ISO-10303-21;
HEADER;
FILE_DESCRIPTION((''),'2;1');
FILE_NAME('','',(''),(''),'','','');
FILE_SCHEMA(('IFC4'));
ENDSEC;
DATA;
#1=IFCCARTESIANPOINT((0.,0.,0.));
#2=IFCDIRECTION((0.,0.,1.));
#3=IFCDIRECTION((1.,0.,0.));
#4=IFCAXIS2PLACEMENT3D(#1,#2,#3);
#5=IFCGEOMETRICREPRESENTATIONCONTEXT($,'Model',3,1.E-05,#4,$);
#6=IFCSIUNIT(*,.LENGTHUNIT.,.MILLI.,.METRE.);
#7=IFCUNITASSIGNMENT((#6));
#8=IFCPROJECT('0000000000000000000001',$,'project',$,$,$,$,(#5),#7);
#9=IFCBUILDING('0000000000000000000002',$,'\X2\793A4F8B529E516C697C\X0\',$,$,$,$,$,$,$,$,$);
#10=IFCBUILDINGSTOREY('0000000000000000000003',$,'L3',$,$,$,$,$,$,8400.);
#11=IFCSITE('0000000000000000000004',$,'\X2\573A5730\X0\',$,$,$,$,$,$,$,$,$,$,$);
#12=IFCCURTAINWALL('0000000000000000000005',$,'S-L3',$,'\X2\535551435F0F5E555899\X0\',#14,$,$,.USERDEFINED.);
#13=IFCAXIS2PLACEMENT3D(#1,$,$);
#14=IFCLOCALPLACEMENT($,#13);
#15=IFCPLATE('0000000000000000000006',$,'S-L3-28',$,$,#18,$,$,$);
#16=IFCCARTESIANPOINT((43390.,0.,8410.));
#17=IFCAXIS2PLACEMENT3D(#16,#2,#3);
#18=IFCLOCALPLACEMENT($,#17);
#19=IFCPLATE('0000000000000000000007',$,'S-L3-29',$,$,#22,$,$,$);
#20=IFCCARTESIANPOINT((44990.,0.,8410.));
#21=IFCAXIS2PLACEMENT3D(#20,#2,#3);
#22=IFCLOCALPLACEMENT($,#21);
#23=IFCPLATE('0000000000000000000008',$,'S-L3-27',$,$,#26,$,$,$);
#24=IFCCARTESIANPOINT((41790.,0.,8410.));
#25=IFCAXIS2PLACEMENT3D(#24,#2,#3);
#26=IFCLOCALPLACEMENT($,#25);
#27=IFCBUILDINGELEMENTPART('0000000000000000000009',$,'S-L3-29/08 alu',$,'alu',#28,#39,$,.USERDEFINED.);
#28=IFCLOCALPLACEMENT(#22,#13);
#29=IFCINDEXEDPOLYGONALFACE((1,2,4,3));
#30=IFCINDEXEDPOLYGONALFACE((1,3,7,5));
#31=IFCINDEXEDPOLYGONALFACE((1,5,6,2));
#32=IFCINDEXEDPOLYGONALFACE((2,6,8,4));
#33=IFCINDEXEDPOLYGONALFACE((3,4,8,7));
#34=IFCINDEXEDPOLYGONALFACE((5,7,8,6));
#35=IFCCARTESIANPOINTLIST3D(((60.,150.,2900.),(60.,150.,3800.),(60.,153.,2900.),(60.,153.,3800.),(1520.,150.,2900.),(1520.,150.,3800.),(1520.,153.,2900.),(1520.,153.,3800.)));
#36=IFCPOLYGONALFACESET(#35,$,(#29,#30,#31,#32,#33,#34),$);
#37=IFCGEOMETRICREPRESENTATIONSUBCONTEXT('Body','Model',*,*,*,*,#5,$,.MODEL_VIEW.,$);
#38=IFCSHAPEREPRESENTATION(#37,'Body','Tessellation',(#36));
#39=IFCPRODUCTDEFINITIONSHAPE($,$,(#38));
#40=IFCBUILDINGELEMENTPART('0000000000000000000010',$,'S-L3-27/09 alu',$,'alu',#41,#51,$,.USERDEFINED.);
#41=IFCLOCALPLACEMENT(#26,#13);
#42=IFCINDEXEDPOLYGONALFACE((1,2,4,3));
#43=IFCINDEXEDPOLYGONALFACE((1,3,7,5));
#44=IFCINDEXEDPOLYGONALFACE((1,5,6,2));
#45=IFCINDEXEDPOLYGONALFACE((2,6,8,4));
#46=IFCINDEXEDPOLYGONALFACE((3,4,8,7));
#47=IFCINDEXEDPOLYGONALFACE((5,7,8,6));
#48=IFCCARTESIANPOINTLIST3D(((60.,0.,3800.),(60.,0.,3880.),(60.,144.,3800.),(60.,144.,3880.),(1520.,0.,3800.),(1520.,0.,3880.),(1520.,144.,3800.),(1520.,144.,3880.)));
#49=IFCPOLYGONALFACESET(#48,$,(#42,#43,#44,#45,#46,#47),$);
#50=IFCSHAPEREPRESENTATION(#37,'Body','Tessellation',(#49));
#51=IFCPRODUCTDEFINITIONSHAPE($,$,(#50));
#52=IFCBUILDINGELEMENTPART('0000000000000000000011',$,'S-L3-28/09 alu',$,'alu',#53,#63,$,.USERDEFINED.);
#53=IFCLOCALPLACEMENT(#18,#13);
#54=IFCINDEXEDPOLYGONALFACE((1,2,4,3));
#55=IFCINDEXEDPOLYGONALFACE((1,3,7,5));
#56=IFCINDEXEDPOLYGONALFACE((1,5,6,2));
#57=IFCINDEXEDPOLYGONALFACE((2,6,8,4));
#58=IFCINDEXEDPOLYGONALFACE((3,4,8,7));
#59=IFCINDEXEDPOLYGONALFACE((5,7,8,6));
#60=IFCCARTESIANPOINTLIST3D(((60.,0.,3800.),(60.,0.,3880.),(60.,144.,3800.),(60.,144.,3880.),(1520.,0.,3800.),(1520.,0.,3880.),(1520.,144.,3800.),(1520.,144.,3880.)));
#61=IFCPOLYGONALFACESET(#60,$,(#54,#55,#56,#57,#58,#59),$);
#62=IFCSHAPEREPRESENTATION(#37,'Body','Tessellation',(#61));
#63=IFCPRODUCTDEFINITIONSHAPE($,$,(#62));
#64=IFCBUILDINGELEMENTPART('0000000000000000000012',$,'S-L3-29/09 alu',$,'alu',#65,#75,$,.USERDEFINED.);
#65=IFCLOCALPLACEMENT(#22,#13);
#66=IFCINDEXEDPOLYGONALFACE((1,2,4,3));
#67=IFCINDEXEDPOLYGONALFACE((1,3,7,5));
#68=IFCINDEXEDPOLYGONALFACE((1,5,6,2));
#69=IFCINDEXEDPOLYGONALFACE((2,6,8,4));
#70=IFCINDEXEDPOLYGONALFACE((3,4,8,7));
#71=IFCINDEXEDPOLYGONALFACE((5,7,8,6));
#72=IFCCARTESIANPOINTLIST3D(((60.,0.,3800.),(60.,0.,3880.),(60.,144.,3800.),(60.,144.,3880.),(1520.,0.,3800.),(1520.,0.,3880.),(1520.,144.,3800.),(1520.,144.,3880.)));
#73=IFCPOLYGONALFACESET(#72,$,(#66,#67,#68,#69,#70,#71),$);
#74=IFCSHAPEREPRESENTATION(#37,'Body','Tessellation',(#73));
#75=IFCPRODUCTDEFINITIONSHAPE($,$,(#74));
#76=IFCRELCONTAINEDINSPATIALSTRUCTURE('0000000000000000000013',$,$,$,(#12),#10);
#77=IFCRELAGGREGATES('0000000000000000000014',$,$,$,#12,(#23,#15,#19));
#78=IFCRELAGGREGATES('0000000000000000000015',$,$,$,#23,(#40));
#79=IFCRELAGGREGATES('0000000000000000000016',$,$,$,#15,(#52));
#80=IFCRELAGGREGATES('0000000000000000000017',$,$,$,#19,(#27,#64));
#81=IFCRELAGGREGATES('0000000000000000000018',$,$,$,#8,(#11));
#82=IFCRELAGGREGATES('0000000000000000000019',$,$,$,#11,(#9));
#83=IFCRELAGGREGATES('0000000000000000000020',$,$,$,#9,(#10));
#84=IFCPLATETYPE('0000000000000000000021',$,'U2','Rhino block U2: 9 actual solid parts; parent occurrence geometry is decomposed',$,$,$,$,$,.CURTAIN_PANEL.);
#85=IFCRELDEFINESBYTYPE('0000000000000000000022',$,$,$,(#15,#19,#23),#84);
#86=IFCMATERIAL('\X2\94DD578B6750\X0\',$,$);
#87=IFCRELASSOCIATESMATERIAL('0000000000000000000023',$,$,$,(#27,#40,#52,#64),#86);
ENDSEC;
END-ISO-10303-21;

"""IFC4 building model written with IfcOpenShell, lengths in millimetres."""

from ifc_helpers import new_model, si_unit, frame, frame_2d, origin, origin_with_axes, place, context, subcontext, project, spatial, rectangle, extrude, source, transform, mapped, material, type_object, element, aggregate, save


model = new_model("IFC4")

# Units and contexts
model_context = context("Model", 3, precision=1e-05, world=origin_with_axes())
body_context = subcontext(model_context, "Body", "Model", "MODEL_VIEW")
ifc_project = project(units=[si_unit("LENGTHUNIT", "METRE", prefix="MILLI")], contexts=[model_context])

# Site, building, storey
site = spatial("IfcSite", under=ifc_project, Name="场地")
building = spatial("IfcBuilding", under=site, Name="示例办公楼")
storey = spatial("IfcBuildingStorey", under=building, Name="L3", Elevation=8400.0)

# Curtain wall, plates, building element parts
curtain_wall = element("IfcCurtainWall", 1, inside=storey, Name="S-L3", ObjectType="单元式幕墙", PredefinedType="USERDEFINED")
plate_type = type_object("IfcPlateType", Name="U2", Description="Rhino block U2: 9 actual solid parts; parent occurrence geometry is decomposed", PredefinedType="CURTAIN_PANEL")
plate_1_placement = place(None, frame((43390.0, 0.0, 8410.0), z_axis=(0.0, 0.0, 1.0), x_axis=(1.0, 0.0, 0.0)))
plate_1 = element("IfcPlate", 2, at=plate_1_placement, type_object=plate_type, Name="S-L3-28")
ifc_material_1 = material(Name="铝型材")
plate_2_placement = place(None, frame((44990.0, 0.0, 8410.0), z_axis=(0.0, 0.0, 1.0), x_axis=(1.0, 0.0, 0.0)))
plate_2 = element("IfcPlate", 3, at=plate_2_placement, type_object=plate_type, Name="S-L3-29")
plate_3_placement = place(None, frame((41790.0, 0.0, 8410.0), z_axis=(0.0, 0.0, 1.0), x_axis=(1.0, 0.0, 0.0)))
plate_3 = element("IfcPlate", 4, at=plate_3_placement, type_object=plate_type, Name="S-L3-27")
aggregate(curtain_wall, [plate_3, plate_1, plate_2])
shared_shape_1 = source(origin(), body_context, "Body", "SweptSolid", [
    extrude(rectangle(XDim=1460.0, YDim=3.0, at=frame_2d((790.0, 151.5))), frame((0.0, 0.0, 2900.0)), (0.0, 0.0, 1.0), 900.0),
])
building_element_part_1_placement = place(plate_2_placement, origin())
building_element_part_1 = element("IfcBuildingElementPart", 5, at=building_element_part_1_placement, material=ifc_material_1, Name="S-L3-29/08 alu", ObjectType="alu", PredefinedType="USERDEFINED", context=body_context, shape_type="MappedRepresentation", body=[
    mapped(shared_shape_1, transform((0.0, 0.0, 0.0))),
])
shared_shape_2 = source(origin(), body_context, "Body", "SweptSolid", [
    extrude(rectangle(XDim=1460.0, YDim=144.0, at=frame_2d((790.0, 72.0))), frame((0.0, 0.0, 3800.0)), (0.0, 0.0, 1.0), 80.0),
])
building_element_part_2_placement = place(plate_3_placement, origin())
building_element_part_2 = element("IfcBuildingElementPart", 6, at=building_element_part_2_placement, material=ifc_material_1, Name="S-L3-27/09 alu", ObjectType="alu", PredefinedType="USERDEFINED", context=body_context, shape_type="MappedRepresentation", body=[
    mapped(shared_shape_2, transform((0.0, 0.0, 0.0))),
])
aggregate(plate_3, [building_element_part_2])
building_element_part_3_placement = place(plate_1_placement, origin())
building_element_part_3 = element("IfcBuildingElementPart", 7, at=building_element_part_3_placement, material=ifc_material_1, Name="S-L3-28/09 alu", ObjectType="alu", PredefinedType="USERDEFINED", context=body_context, shape_type="MappedRepresentation", body=[
    mapped(shared_shape_2, transform((0.0, 0.0, 0.0))),
])
aggregate(plate_1, [building_element_part_3])
building_element_part_4_placement = place(plate_2_placement, origin())
building_element_part_4 = element("IfcBuildingElementPart", 8, at=building_element_part_4_placement, material=ifc_material_1, Name="S-L3-29/09 alu", ObjectType="alu", PredefinedType="USERDEFINED", context=body_context, shape_type="MappedRepresentation", body=[
    mapped(shared_shape_2, transform((0.0, 0.0, 0.0))),
])
aggregate(plate_2, [building_element_part_1, building_element_part_4])

save(model, "model.ifc")
